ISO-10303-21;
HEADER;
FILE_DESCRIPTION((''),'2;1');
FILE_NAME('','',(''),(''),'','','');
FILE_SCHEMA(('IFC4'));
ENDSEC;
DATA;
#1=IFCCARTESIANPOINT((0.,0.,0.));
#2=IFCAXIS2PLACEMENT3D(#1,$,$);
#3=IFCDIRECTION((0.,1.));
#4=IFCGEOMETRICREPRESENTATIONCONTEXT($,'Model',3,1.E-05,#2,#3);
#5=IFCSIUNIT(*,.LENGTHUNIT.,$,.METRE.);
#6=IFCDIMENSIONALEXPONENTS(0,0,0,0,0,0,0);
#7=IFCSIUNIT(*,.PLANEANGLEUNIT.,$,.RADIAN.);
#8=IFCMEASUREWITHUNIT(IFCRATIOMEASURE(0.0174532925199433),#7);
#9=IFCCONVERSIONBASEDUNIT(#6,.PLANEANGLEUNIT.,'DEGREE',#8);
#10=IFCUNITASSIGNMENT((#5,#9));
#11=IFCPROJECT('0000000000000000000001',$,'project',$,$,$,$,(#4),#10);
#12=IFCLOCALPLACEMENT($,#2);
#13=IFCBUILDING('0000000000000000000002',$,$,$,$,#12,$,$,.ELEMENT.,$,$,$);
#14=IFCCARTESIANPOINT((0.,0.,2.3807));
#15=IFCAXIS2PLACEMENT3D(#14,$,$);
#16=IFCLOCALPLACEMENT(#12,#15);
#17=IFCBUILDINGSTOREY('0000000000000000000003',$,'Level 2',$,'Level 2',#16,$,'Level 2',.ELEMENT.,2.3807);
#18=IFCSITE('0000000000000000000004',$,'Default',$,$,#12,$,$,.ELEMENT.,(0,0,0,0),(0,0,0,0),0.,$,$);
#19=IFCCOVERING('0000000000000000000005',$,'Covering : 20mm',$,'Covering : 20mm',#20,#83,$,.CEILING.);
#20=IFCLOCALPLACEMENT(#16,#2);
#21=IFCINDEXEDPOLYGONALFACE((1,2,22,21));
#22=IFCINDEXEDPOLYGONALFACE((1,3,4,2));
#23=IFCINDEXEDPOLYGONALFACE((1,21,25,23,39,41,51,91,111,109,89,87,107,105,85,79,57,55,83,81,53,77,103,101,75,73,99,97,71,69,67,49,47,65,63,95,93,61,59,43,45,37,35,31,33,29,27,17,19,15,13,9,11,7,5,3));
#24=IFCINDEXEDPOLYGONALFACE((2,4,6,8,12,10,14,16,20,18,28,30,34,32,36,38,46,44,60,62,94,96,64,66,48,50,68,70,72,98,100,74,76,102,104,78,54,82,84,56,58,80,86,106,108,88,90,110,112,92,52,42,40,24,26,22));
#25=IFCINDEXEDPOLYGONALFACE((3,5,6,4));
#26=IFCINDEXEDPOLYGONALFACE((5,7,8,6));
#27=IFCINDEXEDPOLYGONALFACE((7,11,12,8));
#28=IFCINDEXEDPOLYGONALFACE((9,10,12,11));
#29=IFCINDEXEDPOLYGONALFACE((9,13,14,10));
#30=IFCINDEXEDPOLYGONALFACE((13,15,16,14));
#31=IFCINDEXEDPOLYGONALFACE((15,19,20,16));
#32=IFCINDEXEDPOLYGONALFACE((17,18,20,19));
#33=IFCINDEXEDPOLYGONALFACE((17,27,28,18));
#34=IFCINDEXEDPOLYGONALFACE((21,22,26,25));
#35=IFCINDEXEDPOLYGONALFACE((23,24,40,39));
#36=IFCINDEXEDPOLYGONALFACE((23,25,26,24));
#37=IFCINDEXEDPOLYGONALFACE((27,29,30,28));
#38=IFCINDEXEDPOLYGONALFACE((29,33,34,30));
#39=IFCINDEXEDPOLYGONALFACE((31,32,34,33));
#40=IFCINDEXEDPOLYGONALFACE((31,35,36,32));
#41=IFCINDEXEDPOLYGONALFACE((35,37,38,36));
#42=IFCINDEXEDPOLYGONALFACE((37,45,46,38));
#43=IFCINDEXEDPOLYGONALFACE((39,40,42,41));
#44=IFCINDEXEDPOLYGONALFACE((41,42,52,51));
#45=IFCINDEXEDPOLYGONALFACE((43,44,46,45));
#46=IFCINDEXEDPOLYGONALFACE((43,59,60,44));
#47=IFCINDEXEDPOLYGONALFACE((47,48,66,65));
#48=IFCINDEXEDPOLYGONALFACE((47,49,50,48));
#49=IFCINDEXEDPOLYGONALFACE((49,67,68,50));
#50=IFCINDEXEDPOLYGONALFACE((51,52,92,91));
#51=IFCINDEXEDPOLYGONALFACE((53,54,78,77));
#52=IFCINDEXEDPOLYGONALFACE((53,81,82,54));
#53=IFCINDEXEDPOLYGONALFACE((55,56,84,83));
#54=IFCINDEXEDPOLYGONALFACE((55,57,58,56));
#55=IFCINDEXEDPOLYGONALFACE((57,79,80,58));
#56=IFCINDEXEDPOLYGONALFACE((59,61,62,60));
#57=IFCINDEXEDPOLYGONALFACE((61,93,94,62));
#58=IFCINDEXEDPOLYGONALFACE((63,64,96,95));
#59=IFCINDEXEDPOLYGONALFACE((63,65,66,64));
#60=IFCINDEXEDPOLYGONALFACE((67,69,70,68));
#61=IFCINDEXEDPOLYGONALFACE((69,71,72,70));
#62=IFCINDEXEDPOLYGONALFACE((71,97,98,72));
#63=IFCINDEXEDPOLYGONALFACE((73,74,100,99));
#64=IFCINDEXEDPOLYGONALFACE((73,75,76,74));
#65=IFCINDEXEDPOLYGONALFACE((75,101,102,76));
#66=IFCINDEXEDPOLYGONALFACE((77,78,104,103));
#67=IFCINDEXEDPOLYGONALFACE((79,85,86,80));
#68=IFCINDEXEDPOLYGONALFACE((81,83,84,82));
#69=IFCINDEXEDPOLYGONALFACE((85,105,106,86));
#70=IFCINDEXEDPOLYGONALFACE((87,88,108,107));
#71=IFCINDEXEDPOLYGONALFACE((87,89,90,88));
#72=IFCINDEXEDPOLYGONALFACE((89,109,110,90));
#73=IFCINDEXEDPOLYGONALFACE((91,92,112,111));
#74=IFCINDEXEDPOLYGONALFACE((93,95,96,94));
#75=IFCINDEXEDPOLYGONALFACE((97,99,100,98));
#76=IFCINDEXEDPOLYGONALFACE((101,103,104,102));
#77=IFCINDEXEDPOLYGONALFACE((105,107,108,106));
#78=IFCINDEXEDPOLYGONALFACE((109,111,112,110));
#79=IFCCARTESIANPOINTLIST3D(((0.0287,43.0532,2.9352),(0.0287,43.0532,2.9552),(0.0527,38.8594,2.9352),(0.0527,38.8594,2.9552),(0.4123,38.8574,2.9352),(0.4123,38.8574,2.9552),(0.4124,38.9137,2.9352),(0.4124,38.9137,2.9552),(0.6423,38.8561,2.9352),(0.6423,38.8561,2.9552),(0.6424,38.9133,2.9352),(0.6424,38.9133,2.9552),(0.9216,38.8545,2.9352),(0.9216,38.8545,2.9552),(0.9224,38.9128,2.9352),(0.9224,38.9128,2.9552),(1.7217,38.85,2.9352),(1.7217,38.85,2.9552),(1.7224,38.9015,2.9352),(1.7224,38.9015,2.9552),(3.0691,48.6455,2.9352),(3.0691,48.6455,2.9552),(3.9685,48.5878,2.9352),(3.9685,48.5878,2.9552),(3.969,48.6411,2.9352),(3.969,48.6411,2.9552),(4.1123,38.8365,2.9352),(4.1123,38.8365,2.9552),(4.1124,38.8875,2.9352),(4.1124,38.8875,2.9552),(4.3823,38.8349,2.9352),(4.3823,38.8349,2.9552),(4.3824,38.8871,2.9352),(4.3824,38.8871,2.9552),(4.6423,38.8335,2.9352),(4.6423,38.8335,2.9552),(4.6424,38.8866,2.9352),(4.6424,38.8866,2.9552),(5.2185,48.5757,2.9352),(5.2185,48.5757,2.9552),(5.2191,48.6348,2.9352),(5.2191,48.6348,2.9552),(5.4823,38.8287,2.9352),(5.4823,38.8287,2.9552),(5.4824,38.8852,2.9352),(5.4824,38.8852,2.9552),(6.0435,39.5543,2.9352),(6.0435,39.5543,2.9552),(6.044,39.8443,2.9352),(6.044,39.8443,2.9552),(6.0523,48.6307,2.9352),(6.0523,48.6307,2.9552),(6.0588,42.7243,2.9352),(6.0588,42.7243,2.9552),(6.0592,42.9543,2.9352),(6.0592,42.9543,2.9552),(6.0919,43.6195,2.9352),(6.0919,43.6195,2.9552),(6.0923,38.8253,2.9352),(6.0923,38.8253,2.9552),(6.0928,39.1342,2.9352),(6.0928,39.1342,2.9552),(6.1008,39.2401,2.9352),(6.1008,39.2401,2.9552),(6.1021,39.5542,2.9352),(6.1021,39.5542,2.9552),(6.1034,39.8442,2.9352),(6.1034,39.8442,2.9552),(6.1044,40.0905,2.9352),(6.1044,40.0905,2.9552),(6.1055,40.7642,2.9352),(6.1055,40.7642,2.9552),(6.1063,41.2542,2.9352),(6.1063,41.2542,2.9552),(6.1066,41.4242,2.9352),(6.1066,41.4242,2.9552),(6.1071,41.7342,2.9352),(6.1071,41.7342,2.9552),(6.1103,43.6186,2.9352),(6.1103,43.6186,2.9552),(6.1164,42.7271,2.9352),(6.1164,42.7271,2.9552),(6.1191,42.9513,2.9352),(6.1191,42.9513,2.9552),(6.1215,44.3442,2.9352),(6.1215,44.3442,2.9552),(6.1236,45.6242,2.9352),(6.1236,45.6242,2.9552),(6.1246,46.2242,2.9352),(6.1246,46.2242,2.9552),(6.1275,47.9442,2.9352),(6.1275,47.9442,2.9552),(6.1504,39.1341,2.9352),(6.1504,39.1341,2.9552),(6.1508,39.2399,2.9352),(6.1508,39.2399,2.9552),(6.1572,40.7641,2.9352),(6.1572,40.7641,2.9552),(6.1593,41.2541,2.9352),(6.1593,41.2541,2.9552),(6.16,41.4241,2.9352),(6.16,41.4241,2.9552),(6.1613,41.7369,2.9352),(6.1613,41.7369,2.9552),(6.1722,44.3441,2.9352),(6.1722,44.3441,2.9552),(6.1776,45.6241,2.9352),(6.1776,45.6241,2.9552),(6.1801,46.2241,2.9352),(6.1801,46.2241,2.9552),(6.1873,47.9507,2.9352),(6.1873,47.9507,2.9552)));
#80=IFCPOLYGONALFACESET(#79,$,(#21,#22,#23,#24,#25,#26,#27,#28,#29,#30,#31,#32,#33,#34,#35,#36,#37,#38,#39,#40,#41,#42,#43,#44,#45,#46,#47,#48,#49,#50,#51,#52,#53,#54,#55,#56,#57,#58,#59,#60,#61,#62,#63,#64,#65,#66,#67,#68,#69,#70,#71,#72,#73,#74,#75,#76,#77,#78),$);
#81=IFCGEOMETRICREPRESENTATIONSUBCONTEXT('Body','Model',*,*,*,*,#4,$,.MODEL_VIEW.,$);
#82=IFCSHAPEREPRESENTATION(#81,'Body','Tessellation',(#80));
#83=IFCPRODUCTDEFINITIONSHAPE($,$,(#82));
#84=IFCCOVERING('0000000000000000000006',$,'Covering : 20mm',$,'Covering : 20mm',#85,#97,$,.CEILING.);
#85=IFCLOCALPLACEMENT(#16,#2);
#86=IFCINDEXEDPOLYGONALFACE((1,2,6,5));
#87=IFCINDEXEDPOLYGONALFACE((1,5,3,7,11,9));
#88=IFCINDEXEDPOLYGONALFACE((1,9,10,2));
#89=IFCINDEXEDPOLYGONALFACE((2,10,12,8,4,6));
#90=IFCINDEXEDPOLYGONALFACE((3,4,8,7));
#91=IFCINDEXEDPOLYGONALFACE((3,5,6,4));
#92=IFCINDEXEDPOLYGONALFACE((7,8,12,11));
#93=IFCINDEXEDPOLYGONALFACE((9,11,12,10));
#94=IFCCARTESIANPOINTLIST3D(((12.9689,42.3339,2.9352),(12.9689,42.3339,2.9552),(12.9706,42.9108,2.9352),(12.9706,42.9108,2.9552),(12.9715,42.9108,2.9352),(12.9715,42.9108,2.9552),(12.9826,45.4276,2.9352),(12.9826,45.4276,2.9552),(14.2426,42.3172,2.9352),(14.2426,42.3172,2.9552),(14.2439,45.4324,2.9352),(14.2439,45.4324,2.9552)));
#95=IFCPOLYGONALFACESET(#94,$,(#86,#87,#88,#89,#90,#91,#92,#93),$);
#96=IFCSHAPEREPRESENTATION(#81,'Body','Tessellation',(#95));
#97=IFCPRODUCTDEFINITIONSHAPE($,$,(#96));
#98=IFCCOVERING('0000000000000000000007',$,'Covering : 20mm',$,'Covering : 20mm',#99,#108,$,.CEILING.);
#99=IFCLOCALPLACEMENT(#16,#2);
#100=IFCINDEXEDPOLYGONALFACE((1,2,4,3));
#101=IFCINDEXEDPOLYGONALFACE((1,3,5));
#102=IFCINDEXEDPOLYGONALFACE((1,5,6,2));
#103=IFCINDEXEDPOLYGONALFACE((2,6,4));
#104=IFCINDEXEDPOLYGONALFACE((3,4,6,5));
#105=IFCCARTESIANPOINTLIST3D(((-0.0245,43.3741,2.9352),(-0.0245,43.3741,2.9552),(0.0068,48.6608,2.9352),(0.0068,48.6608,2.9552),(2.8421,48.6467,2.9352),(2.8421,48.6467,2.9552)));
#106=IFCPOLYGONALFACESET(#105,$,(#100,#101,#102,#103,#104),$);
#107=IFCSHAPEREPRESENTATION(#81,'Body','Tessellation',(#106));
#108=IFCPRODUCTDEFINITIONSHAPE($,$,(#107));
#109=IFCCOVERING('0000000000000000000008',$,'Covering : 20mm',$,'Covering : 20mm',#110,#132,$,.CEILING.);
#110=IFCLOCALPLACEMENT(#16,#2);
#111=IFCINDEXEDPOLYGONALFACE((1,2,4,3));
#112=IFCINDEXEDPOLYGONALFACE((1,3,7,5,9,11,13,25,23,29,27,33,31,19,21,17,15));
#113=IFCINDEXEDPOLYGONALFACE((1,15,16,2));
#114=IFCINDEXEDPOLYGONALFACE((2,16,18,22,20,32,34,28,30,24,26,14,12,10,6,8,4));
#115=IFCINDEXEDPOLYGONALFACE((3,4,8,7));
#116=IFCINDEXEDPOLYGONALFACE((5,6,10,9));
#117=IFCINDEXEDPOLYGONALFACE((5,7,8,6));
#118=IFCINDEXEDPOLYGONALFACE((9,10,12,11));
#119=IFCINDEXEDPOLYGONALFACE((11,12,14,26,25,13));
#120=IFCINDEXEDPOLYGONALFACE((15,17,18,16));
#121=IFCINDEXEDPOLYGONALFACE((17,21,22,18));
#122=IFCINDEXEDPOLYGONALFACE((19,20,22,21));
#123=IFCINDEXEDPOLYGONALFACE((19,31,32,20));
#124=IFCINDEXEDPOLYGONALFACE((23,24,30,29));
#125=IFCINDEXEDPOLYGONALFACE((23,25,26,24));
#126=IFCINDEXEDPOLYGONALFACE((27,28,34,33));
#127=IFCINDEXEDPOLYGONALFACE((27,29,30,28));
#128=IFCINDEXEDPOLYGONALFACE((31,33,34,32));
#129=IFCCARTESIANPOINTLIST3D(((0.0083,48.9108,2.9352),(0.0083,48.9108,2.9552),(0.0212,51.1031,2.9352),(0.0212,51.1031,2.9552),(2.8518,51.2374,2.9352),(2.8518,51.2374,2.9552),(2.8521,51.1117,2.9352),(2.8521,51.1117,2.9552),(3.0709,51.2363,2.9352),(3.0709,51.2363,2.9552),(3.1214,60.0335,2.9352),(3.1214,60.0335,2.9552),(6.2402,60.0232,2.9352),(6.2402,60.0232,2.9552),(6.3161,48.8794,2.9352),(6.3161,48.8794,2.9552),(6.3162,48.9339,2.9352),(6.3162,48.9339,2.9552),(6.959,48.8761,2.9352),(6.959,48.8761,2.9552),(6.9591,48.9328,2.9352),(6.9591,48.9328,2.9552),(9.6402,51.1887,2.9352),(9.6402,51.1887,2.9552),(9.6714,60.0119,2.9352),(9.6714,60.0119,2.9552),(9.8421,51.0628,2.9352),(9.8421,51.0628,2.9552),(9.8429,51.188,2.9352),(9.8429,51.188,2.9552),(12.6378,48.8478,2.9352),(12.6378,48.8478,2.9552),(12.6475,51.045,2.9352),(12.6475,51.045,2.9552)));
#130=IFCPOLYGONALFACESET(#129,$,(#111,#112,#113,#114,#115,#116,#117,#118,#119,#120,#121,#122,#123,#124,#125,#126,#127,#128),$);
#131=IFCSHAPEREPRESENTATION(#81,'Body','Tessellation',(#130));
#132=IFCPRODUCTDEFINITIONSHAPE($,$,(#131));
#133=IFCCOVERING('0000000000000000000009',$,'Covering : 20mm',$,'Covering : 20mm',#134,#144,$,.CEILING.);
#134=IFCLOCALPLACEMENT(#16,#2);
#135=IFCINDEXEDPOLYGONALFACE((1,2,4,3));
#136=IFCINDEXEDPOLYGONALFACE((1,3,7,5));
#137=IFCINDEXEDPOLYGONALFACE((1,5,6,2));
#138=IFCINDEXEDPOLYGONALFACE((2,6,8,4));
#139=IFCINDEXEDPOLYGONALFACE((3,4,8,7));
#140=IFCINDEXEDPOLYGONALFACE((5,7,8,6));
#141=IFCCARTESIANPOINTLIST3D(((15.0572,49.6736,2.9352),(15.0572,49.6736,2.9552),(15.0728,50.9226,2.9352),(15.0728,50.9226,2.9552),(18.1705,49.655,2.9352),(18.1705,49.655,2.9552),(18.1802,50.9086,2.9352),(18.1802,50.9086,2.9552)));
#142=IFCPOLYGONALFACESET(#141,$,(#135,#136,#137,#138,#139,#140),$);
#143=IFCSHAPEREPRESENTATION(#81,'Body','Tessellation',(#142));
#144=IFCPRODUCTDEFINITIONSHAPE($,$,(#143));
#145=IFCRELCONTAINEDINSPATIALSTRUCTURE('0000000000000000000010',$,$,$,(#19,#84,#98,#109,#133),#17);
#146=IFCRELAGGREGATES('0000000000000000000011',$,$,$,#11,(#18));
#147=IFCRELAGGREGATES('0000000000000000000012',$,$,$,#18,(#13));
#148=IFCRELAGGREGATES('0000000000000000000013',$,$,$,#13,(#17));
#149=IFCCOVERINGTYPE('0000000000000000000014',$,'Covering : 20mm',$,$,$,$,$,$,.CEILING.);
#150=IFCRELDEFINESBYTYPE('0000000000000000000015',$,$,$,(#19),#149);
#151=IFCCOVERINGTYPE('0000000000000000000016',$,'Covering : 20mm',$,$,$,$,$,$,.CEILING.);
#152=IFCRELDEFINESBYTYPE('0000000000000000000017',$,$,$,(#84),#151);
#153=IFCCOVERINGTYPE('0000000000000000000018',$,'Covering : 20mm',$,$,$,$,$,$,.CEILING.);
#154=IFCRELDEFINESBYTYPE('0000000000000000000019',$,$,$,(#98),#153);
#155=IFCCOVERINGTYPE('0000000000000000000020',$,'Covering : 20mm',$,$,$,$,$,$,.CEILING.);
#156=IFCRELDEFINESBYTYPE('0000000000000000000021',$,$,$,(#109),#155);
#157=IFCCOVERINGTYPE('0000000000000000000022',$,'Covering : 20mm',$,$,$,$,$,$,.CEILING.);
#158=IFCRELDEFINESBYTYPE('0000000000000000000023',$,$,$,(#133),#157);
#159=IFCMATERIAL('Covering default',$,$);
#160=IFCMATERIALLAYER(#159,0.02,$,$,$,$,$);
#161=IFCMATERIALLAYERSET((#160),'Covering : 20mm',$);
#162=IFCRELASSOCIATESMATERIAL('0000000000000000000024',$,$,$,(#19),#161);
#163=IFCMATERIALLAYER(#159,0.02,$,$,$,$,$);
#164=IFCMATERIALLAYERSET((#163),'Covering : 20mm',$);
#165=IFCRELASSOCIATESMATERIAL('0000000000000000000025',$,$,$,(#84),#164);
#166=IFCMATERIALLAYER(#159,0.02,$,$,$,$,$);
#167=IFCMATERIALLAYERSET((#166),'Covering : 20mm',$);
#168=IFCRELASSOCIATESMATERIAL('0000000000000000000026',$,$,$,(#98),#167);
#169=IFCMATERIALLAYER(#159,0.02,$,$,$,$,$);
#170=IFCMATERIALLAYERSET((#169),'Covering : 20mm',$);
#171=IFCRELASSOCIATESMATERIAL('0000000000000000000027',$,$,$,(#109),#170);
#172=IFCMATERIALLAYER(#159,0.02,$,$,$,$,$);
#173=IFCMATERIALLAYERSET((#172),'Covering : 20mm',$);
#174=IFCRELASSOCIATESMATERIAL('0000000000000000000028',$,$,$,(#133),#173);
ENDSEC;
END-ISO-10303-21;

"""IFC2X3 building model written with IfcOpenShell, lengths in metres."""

from ifc_helpers import new_model, entity, si_unit, converted_unit, direction, frame, origin, origin_with_axes, place, context, subcontext, project, spatial, polyline, outline, extrude, material, layer, layer_set, layer_usage, type_object, element, save


model = new_model("IFC2X3")

# Units and contexts
model_context = context("Model", 3, precision=1e-05, world=origin(), true_north=direction((0.0, 1.0)))
body_context = subcontext(model_context, "Body", "Model", "MODEL_VIEW")
ifc_project = project(units=[si_unit("LENGTHUNIT", "METRE"), converted_unit("PLANEANGLEUNIT", "DEGREE", entity("IfcRatioMeasure", 0.0174532925199433), si_unit("PLANEANGLEUNIT", "RADIAN"), dimensions=[0, 0, 0, 0, 0, 0, 0])], contexts=[model_context])

# Site, building, storey
placement = place(None, origin())
site = spatial("IfcSite", under=ifc_project, at=placement, Name="Default", CompositionType="ELEMENT", RefLatitude=(0, 0, 0, 0), RefLongitude=(0, 0, 0, 0), RefElevation=0.0)
building = spatial("IfcBuilding", under=site, at=placement, CompositionType="ELEMENT")
storey_placement = place(placement, frame((0.0, 0.0, 2.3807)))
storey = spatial("IfcBuildingStorey", under=building, at=storey_placement, Name="Level 2", ObjectType="Level 2", LongName="Level 2", CompositionType="ELEMENT", Elevation=2.3807)

# Coverings
ifc_material_1 = material(Name="Covering default")
ifc_layer_1 = layer(ifc_material_1, 0.02)
ifc_layer_set_1 = layer_set([ifc_layer_1], Name="Covering : 20mm")
ifc_layer_usage_1 = layer_usage(ifc_layer_set_1, "AXIS3", "POSITIVE", 0.0)
covering_type_1 = type_object("IfcCoveringType", Name="Covering : 20mm", PredefinedType="CEILING")
covering_1_placement = place(placement, frame((0.0, 0.0, 5.3159)))
element("IfcCovering", 1, at=covering_1_placement, inside=storey, type_object=covering_type_1, material=ifc_layer_usage_1, Name="Covering : 20mm", ObjectType="Covering : 20mm", PredefinedType="CEILING", context=body_context, shape_type="SweptSolid", body=[
    extrude(outline(polyline([(0.0527, 38.8594), (0.4123, 38.8574), (0.4124, 38.9137), (0.6424, 38.9133), (0.6423, 38.8561), (0.9216, 38.8545), (0.9224, 38.9128), (1.7224, 38.9015), (1.7217, 38.85), (4.1123, 38.8365), (4.1124, 38.8875), (4.3824, 38.8871), (4.3823, 38.8349), (4.6423, 38.8335), (4.6424, 38.8866), (5.4824, 38.8852), (5.4823, 38.8287), (6.0923, 38.8253), (6.0928, 39.1342), (6.1504, 39.1341), (6.1508, 39.2399), (6.1008, 39.2401), (6.1021, 39.5542), (6.0435, 39.5543), (6.044, 39.8443), (6.1034, 39.8442), (6.1044, 40.0905), (6.1055, 40.7642), (6.1572, 40.7641), (6.1593, 41.2541), (6.1063, 41.2542), (6.1066, 41.4242), (6.16, 41.4241), (6.1613, 41.7369), (6.1071, 41.7342), (6.0588, 42.7243), (6.1164, 42.7271), (6.1191, 42.9513), (6.0592, 42.9543), (6.0919, 43.6195), (6.1103, 43.6186), (6.1215, 44.3442), (6.1722, 44.3441), (6.1776, 45.6241), (6.1236, 45.6242), (6.1246, 46.2242), (6.1801, 46.2241), (6.1873, 47.9507), (6.1275, 47.9442), (6.0523, 48.6307), (5.2191, 48.6348), (5.2185, 48.5757), (3.9685, 48.5878), (3.969, 48.6411), (3.0691, 48.6455), (0.0287, 43.0532), (0.0527, 38.8594)])), origin_with_axes(), (0.0, 0.0, 1.0), 0.02),
])
ifc_layer_2 = layer(ifc_material_1, 0.02)
ifc_layer_set_2 = layer_set([ifc_layer_2], Name="Covering : 20mm")
ifc_layer_usage_2 = layer_usage(ifc_layer_set_2, "AXIS3", "POSITIVE", 0.0)
covering_type_2 = type_object("IfcCoveringType", Name="Covering : 20mm", PredefinedType="CEILING")
covering_2_placement = place(placement, frame((0.0, 0.0, 5.3159)))
element("IfcCovering", 2, at=covering_2_placement, inside=storey, type_object=covering_type_2, material=ifc_layer_usage_2, Name="Covering : 20mm", ObjectType="Covering : 20mm", PredefinedType="CEILING", context=body_context, shape_type="SweptSolid", body=[
    extrude(outline(polyline([(12.9715, 42.9108), (12.9706, 42.9108), (12.9826, 45.4276), (14.2439, 45.4324), (14.2426, 42.3172), (12.9689, 42.3339), (12.9715, 42.9108)])), origin_with_axes(), (0.0, 0.0, 1.0), 0.02),
])
ifc_layer_3 = layer(ifc_material_1, 0.02)
ifc_layer_set_3 = layer_set([ifc_layer_3], Name="Covering : 20mm")
ifc_layer_usage_3 = layer_usage(ifc_layer_set_3, "AXIS3", "POSITIVE", 0.0)
covering_type_3 = type_object("IfcCoveringType", Name="Covering : 20mm", PredefinedType="CEILING")
covering_3_placement = place(placement, frame((0.0, 0.0, 5.3159)))
element("IfcCovering", 3, at=covering_3_placement, inside=storey, type_object=covering_type_3, material=ifc_layer_usage_3, Name="Covering : 20mm", ObjectType="Covering : 20mm", PredefinedType="CEILING", context=body_context, shape_type="SweptSolid", body=[
    extrude(outline(polyline([(0.0068, 48.6608), (2.8421, 48.6467), (-0.0245, 43.3741), (0.0068, 48.6608)])), origin_with_axes(), (0.0, 0.0, 1.0), 0.02),
])
ifc_layer_4 = layer(ifc_material_1, 0.02)
ifc_layer_set_4 = layer_set([ifc_layer_4], Name="Covering : 20mm")
ifc_layer_usage_4 = layer_usage(ifc_layer_set_4, "AXIS3", "POSITIVE", 0.0)
covering_type_4 = type_object("IfcCoveringType", Name="Covering : 20mm", PredefinedType="CEILING")
covering_4_placement = place(placement, frame((0.0, 0.0, 5.3159)))
element("IfcCovering", 4, at=covering_4_placement, inside=storey, type_object=covering_type_4, material=ifc_layer_usage_4, Name="Covering : 20mm", ObjectType="Covering : 20mm", PredefinedType="CEILING", context=body_context, shape_type="SweptSolid", body=[
    extrude(outline(polyline([(0.0212, 51.1031), (2.8521, 51.1117), (2.8518, 51.2374), (3.0709, 51.2363), (3.1214, 60.0335), (6.2402, 60.0232), (9.6714, 60.0119), (9.6402, 51.1887), (9.8429, 51.188), (9.8421, 51.0628), (12.6475, 51.045), (12.6378, 48.8478), (6.959, 48.8761), (6.9591, 48.9328), (6.3162, 48.9339), (6.3161, 48.8794), (0.0083, 48.9108), (0.0212, 51.1031)])), origin_with_axes(), (0.0, 0.0, 1.0), 0.02),
])
ifc_layer_5 = layer(ifc_material_1, 0.02)
ifc_layer_set_5 = layer_set([ifc_layer_5], Name="Covering : 20mm")
ifc_layer_usage_5 = layer_usage(ifc_layer_set_5, "AXIS3", "POSITIVE", 0.0)
covering_type_5 = type_object("IfcCoveringType", Name="Covering : 20mm", PredefinedType="CEILING")
covering_5_placement = place(placement, frame((0.0, 0.0, 5.3159)))
element("IfcCovering", 5, at=covering_5_placement, inside=storey, type_object=covering_type_5, material=ifc_layer_usage_5, Name="Covering : 20mm", ObjectType="Covering : 20mm", PredefinedType="CEILING", context=body_context, shape_type="SweptSolid", body=[
    extrude(outline(polyline([(15.0728, 50.9226), (18.1802, 50.9086), (18.1705, 49.655), (15.0572, 49.6736), (15.0728, 50.9226)])), origin_with_axes(), (0.0, 0.0, 1.0), 0.02),
])

save(model, "model.ifc")
